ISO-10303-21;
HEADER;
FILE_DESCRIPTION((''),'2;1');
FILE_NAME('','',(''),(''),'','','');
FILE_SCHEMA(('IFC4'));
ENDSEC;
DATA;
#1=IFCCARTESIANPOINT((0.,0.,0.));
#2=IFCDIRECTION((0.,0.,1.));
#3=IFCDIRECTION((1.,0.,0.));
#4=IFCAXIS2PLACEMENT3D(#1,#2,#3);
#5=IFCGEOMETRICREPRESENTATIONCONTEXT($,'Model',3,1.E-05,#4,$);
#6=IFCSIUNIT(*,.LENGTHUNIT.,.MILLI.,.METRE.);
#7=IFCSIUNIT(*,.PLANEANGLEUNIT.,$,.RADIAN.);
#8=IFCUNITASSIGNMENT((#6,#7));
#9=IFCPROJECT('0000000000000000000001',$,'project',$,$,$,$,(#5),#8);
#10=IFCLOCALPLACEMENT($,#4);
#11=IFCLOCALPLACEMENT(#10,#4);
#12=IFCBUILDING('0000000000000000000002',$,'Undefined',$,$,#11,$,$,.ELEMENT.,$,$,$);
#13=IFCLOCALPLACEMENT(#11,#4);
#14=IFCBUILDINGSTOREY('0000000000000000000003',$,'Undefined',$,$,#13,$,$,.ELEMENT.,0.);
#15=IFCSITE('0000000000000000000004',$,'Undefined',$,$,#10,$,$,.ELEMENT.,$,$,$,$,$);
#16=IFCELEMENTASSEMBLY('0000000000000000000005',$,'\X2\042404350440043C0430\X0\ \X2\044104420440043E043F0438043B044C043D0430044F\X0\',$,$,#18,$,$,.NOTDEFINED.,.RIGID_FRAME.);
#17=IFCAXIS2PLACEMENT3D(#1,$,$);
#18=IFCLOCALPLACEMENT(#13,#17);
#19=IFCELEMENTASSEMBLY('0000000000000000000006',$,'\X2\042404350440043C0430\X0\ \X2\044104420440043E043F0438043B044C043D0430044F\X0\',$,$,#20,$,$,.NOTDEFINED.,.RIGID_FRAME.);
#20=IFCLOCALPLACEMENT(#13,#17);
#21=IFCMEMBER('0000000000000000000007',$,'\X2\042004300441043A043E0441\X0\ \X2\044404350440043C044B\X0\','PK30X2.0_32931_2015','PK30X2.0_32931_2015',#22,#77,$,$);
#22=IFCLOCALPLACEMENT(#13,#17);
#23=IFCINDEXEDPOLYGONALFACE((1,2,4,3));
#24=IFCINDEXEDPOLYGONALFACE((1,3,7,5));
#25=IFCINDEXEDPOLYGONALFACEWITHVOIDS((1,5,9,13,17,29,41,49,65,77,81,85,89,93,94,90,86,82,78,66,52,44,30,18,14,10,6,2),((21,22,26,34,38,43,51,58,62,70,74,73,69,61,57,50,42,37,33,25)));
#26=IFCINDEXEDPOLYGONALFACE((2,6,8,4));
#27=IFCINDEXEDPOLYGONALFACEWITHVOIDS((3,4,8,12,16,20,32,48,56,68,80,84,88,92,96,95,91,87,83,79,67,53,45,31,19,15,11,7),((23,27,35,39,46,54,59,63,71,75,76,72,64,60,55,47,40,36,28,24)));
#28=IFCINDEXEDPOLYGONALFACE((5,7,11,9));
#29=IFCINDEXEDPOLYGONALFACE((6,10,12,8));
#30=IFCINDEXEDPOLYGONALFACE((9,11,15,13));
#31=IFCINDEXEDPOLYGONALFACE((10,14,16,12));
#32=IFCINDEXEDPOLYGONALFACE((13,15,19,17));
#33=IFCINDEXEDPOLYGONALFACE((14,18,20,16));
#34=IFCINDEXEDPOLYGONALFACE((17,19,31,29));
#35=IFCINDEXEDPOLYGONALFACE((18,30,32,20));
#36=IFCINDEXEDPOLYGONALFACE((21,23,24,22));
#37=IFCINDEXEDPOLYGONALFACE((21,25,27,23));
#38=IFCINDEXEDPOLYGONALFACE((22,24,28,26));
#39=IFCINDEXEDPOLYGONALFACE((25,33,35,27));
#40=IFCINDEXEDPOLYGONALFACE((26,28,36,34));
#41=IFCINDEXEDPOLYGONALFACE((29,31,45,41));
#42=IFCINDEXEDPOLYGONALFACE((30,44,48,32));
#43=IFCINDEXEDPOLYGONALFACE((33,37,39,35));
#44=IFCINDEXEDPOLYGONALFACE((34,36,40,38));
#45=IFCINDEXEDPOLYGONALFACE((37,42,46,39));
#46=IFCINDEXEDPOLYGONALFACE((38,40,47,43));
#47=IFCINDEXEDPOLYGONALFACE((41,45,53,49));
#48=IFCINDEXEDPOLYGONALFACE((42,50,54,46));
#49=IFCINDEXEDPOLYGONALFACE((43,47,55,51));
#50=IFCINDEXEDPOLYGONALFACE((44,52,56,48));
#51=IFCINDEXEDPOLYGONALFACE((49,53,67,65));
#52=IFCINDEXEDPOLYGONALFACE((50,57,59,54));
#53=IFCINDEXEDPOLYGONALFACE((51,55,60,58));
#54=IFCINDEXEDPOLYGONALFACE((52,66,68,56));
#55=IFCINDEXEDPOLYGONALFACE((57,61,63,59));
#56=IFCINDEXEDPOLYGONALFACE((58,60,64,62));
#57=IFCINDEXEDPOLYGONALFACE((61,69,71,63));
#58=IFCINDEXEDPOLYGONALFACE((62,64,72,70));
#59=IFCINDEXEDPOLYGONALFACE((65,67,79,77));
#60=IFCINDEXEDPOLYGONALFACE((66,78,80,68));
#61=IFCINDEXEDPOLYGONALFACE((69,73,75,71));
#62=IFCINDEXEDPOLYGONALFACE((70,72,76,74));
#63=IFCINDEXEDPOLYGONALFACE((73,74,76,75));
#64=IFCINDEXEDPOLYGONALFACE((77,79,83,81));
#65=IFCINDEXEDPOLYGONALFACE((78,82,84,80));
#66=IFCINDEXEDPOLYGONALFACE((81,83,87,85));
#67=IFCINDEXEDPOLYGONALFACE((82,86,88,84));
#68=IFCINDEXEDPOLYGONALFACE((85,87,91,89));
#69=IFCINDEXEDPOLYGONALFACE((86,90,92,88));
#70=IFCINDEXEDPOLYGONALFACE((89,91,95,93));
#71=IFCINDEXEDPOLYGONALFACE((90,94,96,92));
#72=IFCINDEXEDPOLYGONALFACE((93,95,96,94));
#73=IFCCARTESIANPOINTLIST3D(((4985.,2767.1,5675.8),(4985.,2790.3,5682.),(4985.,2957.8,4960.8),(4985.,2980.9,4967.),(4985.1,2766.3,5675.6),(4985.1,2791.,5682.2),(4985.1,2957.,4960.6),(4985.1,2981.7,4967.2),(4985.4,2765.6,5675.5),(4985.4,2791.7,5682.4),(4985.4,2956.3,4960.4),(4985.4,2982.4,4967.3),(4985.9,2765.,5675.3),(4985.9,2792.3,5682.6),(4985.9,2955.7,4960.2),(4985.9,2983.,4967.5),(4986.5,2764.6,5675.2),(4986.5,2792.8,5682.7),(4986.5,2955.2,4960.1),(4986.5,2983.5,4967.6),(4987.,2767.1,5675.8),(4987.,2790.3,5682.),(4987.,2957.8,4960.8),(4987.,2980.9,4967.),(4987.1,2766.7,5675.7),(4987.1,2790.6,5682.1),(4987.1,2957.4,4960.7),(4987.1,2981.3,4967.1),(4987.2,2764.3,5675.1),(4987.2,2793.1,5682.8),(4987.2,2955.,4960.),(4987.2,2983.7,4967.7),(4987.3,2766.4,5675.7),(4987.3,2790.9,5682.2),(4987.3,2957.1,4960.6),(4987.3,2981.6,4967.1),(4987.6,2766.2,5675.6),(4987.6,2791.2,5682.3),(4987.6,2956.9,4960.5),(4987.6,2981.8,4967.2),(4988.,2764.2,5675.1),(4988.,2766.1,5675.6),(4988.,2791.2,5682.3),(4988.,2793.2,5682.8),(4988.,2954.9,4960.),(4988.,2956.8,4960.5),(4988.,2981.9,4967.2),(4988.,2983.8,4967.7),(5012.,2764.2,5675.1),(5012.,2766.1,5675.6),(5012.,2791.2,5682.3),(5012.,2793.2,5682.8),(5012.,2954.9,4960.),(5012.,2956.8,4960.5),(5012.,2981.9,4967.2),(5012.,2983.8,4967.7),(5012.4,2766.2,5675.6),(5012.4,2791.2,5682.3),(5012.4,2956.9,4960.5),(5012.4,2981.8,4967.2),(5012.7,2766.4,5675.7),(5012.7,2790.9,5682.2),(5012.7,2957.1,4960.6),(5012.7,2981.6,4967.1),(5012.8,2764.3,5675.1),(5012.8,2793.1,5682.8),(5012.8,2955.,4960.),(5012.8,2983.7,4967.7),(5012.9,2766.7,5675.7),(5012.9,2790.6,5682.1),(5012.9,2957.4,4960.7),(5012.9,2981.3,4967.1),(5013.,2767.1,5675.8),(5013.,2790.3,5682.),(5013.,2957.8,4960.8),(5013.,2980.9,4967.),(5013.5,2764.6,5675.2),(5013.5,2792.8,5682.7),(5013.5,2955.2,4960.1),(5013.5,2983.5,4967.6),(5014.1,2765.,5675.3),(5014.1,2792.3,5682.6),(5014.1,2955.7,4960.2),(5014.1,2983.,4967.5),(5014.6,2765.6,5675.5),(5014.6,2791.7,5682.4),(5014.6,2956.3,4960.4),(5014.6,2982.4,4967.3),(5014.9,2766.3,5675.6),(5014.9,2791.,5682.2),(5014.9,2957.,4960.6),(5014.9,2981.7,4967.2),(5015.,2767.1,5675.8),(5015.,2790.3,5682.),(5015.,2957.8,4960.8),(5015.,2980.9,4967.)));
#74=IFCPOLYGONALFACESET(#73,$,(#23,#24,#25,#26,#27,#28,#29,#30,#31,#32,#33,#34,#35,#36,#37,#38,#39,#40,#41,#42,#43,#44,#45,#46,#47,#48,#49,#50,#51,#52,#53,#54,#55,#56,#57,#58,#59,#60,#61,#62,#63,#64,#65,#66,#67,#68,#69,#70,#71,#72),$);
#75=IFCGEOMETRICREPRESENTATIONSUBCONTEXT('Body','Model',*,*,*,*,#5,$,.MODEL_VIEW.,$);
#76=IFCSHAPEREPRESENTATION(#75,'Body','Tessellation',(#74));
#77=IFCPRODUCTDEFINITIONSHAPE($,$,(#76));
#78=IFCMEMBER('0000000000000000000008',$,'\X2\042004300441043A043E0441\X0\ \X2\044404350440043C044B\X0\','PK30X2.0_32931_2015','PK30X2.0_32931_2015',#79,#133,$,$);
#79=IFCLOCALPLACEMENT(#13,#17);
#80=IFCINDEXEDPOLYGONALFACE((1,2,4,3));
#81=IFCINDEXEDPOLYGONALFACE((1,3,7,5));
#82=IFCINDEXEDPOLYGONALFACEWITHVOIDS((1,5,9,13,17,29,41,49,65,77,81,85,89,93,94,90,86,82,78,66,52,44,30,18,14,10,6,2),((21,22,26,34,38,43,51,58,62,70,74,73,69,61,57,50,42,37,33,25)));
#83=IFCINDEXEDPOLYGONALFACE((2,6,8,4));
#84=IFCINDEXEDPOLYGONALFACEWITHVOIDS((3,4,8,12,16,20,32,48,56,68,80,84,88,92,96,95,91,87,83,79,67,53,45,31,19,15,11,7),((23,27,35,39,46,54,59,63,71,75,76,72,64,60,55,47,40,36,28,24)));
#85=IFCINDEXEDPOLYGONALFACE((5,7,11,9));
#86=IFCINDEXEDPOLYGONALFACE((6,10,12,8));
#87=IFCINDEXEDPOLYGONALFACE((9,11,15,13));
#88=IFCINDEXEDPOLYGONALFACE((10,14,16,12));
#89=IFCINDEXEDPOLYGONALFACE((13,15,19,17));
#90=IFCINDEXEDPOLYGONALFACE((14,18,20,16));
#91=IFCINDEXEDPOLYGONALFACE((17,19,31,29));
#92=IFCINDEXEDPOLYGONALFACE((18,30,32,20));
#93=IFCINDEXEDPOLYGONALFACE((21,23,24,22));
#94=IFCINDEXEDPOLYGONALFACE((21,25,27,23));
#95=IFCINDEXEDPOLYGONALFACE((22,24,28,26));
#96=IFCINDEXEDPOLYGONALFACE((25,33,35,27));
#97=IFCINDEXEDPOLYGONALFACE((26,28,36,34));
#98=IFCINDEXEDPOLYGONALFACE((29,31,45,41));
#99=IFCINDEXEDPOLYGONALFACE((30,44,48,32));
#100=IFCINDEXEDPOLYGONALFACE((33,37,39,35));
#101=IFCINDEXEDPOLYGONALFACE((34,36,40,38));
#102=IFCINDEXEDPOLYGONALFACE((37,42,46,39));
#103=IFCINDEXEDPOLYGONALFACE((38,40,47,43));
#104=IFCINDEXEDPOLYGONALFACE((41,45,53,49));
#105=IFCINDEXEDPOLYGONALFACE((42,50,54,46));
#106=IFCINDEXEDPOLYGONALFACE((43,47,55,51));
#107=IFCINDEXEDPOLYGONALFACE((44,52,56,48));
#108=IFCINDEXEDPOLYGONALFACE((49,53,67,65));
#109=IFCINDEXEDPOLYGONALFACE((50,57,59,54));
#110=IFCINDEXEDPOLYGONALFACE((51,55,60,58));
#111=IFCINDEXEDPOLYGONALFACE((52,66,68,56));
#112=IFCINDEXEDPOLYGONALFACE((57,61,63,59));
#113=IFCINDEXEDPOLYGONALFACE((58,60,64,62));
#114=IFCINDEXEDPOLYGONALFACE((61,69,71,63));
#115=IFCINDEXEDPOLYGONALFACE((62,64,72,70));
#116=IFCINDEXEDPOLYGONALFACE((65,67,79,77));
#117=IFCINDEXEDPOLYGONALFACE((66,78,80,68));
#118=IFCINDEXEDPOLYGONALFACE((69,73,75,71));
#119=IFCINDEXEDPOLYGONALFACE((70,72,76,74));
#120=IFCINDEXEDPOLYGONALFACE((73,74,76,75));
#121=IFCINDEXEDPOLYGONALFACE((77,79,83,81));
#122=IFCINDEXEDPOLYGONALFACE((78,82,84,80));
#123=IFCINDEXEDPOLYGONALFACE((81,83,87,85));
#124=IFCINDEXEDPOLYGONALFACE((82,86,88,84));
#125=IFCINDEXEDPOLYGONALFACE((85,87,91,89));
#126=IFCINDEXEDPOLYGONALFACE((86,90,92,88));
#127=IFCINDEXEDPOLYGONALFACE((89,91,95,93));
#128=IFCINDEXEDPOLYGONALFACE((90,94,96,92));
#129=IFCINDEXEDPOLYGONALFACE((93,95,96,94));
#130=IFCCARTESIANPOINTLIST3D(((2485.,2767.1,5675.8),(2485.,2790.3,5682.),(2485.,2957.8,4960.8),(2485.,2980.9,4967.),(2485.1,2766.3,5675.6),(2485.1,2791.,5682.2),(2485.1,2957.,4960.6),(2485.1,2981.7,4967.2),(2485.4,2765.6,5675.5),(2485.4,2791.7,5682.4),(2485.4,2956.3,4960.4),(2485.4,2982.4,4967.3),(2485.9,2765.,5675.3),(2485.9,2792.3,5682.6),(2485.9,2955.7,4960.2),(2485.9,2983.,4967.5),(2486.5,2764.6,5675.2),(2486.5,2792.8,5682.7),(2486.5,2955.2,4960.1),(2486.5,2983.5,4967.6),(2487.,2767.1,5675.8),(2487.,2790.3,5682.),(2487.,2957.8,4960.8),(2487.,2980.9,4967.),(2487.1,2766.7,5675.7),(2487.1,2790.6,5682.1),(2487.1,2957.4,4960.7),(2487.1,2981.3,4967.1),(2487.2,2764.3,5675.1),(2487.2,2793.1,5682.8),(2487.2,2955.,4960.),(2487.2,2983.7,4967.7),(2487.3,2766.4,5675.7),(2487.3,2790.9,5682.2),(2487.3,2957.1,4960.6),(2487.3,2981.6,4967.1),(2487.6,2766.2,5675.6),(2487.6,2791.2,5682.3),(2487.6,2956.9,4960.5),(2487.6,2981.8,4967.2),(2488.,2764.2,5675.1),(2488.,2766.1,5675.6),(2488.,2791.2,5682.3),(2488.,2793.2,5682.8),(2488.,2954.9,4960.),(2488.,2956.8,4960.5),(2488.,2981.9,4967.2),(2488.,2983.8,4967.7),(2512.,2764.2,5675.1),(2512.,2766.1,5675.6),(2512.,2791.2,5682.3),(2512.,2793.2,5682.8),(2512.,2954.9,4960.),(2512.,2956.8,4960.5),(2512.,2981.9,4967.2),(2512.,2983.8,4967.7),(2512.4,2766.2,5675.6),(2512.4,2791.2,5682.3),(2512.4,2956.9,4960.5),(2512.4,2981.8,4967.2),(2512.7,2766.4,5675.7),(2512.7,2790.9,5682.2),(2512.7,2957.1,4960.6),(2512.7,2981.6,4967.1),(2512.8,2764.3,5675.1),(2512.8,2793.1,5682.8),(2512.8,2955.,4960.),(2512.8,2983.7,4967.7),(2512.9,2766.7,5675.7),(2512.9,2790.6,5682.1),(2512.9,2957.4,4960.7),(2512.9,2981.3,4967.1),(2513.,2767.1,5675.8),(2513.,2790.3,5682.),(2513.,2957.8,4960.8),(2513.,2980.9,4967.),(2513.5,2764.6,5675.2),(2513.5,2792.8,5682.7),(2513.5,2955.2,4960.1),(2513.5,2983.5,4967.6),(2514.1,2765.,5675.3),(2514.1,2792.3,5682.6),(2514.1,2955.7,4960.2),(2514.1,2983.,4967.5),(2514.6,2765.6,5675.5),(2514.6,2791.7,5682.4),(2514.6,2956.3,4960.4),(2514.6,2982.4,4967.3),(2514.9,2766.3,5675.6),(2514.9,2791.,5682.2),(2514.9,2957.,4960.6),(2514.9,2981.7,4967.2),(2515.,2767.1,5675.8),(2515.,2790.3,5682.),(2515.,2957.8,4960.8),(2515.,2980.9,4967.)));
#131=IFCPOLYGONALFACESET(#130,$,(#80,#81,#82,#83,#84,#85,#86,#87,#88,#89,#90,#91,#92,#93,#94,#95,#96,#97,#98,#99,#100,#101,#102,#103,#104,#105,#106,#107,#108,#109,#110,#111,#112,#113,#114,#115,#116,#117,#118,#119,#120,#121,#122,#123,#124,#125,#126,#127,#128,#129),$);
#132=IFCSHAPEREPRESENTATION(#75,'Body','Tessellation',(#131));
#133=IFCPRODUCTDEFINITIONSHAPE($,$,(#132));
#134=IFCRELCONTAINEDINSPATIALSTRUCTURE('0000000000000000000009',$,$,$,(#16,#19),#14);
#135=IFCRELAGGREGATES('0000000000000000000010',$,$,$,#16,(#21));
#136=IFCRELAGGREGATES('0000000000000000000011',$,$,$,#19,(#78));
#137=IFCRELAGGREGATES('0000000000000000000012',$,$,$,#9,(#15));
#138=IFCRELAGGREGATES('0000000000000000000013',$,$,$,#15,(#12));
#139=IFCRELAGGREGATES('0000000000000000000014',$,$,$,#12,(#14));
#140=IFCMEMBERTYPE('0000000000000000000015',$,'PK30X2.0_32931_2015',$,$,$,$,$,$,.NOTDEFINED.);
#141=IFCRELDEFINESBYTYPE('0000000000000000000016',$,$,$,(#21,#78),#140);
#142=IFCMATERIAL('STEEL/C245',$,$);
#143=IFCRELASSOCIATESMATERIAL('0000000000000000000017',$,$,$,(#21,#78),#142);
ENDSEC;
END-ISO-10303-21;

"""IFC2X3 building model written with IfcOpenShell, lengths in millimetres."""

from ifc_helpers import new_model, si_unit, frame, origin_with_axes, origin_2d_with_axis, place, context, subcontext, project, spatial, hollow_rectangle, extrude, material, type_object, element, aggregate, save


model = new_model("IFC2X3")

# Units and contexts
model_context = context("Model", 3, precision=1e-05, world=origin_with_axes())
body_context = subcontext(model_context, "Body", "Model", "MODEL_VIEW")
ifc_project = project(units=[si_unit("LENGTHUNIT", "METRE", prefix="MILLI"), si_unit("PLANEANGLEUNIT", "RADIAN")], contexts=[model_context])

# Site, building, storey
site_placement = place(None, origin_with_axes())
site = spatial("IfcSite", under=ifc_project, at=site_placement, Name="Undefined", CompositionType="ELEMENT")
building_placement = place(site_placement, origin_with_axes())
building = spatial("IfcBuilding", under=site, at=building_placement, Name="Undefined", CompositionType="ELEMENT")
storey_placement = place(building_placement, origin_with_axes())
storey = spatial("IfcBuildingStorey", under=building, at=storey_placement, Name="Undefined", CompositionType="ELEMENT", Elevation=0.0)

# Shared definitions
ifc_material_1 = material(Name="STEEL/C245")

# Element assemblies
assembly_1_placement = place(storey_placement, origin_with_axes())
assembly_1 = element("IfcElementAssembly", 1, at=assembly_1_placement, inside=storey, Name="Ферма стропильная", AssemblyPlace="NOTDEFINED", PredefinedType="RIGID_FRAME")
assembly_2_placement = place(storey_placement, origin_with_axes())
assembly_2 = element("IfcElementAssembly", 2, at=assembly_2_placement, inside=storey, Name="Ферма стропильная", AssemblyPlace="NOTDEFINED", PredefinedType="RIGID_FRAME")

# Members
member_type_1 = type_object("IfcMemberType", Name="PK30X2.0_32931_2015", PredefinedType="NOTDEFINED")
member_1_placement = place(assembly_1_placement, frame((5000.0, 2778.7, 5678.9), z_axis=(0.0, -0.966235, -0.257663), x_axis=(0.0, 0.257663, -0.966235)))
member_1 = element("IfcMember", 3, at=member_1_placement, type_object=member_type_1, material=ifc_material_1, Name="Раскос фермы", Description="PK30X2.0_32931_2015", ObjectType="PK30X2.0_32931_2015", context=body_context, shape_type="SweptSolid", body=[
    extrude(hollow_rectangle(XDim=30.0, YDim=30.0, WallThickness=2.0, InnerFilletRadius=1.0, OuterFilletRadius=3.0, at=origin_2d_with_axis()), frame((740.0, 0.0, 0.0), z_axis=(-1.0, 0.0, 0.0), x_axis=(0.0, -1.0, 0.0)), (0.0, 0.0, 1.0), 740.0),
])
aggregate(assembly_1, [member_1])
member_2_placement = place(assembly_2_placement, frame((2500.0, 2778.7, 5678.9), z_axis=(0.0, -0.966235, -0.257663), x_axis=(0.0, 0.257663, -0.966235)))
member_2 = element("IfcMember", 4, at=member_2_placement, type_object=member_type_1, material=ifc_material_1, Name="Раскос фермы", Description="PK30X2.0_32931_2015", ObjectType="PK30X2.0_32931_2015", context=body_context, shape_type="SweptSolid", body=[
    extrude(hollow_rectangle(XDim=30.0, YDim=30.0, WallThickness=2.0, InnerFilletRadius=1.0, OuterFilletRadius=3.0, at=origin_2d_with_axis()), frame((740.0, 0.0, 0.0), z_axis=(-1.0, 0.0, 0.0), x_axis=(0.0, -1.0, 0.0)), (0.0, 0.0, 1.0), 740.0),
])
aggregate(assembly_2, [member_2])

save(model, "model.ifc")
